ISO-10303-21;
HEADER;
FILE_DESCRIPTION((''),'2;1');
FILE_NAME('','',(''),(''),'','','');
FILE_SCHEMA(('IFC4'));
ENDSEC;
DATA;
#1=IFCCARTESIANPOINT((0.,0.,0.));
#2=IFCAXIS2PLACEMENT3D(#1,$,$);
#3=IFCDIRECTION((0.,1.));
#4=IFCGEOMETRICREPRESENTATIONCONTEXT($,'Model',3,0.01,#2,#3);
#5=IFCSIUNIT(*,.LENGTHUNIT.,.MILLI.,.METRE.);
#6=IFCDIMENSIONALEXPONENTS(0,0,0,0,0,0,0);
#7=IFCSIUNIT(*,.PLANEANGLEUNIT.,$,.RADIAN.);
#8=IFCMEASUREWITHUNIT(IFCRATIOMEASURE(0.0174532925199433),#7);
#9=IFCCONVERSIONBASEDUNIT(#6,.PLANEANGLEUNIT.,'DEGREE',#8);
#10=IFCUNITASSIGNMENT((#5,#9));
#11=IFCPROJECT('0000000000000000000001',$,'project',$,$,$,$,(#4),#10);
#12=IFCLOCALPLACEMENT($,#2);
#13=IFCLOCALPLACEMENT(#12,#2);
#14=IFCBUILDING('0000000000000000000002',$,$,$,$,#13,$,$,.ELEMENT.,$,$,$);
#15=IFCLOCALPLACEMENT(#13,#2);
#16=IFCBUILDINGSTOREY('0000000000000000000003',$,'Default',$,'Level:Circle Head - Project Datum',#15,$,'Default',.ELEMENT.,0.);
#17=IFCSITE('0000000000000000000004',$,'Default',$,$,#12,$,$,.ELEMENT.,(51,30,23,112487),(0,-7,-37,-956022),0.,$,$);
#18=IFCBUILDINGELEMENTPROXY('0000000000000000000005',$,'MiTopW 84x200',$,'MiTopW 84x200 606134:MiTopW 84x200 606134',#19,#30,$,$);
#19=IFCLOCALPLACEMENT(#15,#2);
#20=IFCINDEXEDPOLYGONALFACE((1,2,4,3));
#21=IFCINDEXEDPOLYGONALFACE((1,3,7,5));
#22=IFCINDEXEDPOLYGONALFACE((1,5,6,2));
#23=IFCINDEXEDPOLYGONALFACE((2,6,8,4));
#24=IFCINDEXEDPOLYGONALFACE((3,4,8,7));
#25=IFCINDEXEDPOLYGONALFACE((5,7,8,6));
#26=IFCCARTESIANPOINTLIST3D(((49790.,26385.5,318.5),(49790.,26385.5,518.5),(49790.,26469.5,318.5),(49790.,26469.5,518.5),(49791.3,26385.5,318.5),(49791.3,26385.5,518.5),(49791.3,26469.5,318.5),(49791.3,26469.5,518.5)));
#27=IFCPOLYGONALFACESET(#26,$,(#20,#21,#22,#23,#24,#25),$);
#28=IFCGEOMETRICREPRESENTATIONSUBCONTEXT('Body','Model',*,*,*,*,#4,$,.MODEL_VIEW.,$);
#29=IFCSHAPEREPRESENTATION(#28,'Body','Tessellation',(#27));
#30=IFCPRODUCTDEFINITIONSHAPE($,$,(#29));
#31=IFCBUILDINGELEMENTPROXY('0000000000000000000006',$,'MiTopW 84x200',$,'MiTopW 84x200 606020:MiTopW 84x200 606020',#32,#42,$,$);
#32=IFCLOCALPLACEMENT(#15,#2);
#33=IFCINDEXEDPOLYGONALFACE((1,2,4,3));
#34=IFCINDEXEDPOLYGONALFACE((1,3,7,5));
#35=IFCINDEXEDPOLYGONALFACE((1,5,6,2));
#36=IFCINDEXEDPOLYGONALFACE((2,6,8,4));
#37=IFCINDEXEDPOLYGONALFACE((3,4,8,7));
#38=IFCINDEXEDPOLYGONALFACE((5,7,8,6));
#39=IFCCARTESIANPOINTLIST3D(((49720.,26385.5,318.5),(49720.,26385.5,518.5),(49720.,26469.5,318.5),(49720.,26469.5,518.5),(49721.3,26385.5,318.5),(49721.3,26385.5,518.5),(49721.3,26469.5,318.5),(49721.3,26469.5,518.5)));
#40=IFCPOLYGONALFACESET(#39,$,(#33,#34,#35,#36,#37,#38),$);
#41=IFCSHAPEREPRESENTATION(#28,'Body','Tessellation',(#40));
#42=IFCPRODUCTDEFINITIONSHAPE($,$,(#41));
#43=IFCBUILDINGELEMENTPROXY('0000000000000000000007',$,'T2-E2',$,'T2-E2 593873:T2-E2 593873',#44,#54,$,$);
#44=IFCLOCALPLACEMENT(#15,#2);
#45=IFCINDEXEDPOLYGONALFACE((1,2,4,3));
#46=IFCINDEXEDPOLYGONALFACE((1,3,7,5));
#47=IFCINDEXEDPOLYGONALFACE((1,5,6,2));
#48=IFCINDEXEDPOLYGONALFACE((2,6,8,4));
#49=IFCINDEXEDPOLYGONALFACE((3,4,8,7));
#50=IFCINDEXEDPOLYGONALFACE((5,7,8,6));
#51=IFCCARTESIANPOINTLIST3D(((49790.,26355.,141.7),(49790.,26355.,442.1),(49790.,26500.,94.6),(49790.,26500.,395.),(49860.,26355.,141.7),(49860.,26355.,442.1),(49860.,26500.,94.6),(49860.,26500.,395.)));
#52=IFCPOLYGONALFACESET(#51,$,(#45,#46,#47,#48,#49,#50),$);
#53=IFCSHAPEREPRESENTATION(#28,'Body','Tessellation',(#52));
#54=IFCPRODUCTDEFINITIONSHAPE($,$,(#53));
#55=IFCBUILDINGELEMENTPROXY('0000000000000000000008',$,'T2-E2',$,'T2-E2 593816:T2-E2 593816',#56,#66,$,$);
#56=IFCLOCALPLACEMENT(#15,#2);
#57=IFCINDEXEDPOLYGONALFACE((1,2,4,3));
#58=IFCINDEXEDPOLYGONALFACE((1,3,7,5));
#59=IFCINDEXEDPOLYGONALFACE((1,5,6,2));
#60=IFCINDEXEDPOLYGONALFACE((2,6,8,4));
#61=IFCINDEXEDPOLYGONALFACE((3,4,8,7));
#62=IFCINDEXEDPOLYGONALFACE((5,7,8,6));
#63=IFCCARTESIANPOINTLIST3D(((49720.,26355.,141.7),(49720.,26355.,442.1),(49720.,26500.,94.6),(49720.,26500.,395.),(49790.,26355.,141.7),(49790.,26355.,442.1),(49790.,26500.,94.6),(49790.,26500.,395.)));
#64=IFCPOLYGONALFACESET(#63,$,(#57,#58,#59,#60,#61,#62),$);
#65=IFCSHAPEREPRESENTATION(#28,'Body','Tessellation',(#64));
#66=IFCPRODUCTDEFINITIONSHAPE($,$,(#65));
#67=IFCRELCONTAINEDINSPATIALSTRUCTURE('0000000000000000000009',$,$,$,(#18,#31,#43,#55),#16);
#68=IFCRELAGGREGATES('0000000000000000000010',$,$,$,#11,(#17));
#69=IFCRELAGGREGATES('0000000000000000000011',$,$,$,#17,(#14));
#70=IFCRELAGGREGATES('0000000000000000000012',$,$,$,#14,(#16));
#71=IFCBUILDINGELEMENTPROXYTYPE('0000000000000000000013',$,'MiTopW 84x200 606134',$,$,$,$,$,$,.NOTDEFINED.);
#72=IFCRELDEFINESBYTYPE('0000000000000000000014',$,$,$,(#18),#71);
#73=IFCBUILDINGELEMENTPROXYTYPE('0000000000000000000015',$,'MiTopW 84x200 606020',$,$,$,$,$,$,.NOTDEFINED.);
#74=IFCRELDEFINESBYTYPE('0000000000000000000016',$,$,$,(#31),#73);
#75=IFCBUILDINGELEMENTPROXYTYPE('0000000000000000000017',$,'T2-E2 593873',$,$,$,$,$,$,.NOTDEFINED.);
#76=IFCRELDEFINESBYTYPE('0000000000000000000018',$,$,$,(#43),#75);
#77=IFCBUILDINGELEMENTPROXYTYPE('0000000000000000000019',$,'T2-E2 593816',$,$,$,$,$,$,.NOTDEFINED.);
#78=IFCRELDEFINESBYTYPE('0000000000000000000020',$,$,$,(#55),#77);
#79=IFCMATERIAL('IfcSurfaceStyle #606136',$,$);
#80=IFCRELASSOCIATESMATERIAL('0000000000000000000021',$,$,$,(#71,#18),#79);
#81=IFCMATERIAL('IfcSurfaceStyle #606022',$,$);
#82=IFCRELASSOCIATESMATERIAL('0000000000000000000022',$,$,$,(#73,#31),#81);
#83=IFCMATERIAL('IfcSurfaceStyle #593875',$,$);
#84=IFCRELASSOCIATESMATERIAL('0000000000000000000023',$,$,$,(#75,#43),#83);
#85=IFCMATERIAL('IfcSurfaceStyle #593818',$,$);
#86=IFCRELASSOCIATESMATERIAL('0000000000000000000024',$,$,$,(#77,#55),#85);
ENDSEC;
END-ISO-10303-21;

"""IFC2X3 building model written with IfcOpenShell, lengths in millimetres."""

from ifc_helpers import new_model, entity, si_unit, converted_unit, direction, frame, frame_2d, origin, place, context, subcontext, project, spatial, polyline, rectangle, outline, extrude, source, transform, mapped, material, type_object, type_shapes, element, save


model = new_model("IFC2X3")

# Units and contexts
model_context = context("Model", 3, precision=0.01, world=origin(), true_north=direction((0.0, 1.0)))
body_context = subcontext(model_context, "Body", "Model", "MODEL_VIEW")
ifc_project = project(units=[si_unit("LENGTHUNIT", "METRE", prefix="MILLI"), converted_unit("PLANEANGLEUNIT", "DEGREE", entity("IfcRatioMeasure", 0.0174532925199433), si_unit("PLANEANGLEUNIT", "RADIAN"), dimensions=[0, 0, 0, 0, 0, 0, 0])], contexts=[model_context])

# Site, building, storey
site_placement = place(None, origin())
site = spatial("IfcSite", under=ifc_project, at=site_placement, Name="Default", CompositionType="ELEMENT", RefLatitude=(51, 30, 23, 112487), RefLongitude=(0, -7, -37, -956022), RefElevation=0.0)
building_placement = place(site_placement, origin())
building = spatial("IfcBuilding", under=site, at=building_placement, CompositionType="ELEMENT")
storey_placement = place(building_placement, origin())
storey = spatial("IfcBuildingStorey", under=building, at=storey_placement, Name="Default", ObjectType="Level:Circle Head - Project Datum", LongName="Default", CompositionType="ELEMENT", Elevation=0.0)

# Building element proxies
ifc_material_1 = material(Name="IfcSurfaceStyle #606136")
building_element_proxy_type_1 = type_object("IfcBuildingElementProxyType", Name="MiTopW 84x200 606134", PredefinedType="NOTDEFINED", material=ifc_material_1)
shared_shape_1 = source(origin(), body_context, "Body", "SweptSolid", [
    extrude(rectangle(XDim=200.0, YDim=84.0, at=frame_2d((0.0, 0.0), x_axis=(1.0, 0.0))), frame((100.0, 42.0, 0.0), z_axis=(0.0, 0.0, 1.0), x_axis=(-1.0, 0.0, 0.0)), (0.0, 0.0, 1.0), 1.3),
])
type_shapes(building_element_proxy_type_1, [shared_shape_1])
proxy_1_placement = place(building_placement, frame((49791.3, 26469.5, 518.5), z_axis=(-1.0, 0.0, 0.0), x_axis=(0.0, 0.0, -1.0)))
element("IfcBuildingElementProxy", 1, at=proxy_1_placement, inside=storey, type_object=building_element_proxy_type_1, material=ifc_material_1, Name="MiTopW 84x200", ObjectType="MiTopW 84x200 606134:MiTopW 84x200 606134", context=body_context, shape_type="MappedRepresentation", body=[
    mapped(shared_shape_1, transform((0.0, 0.0, 0.0), scale=1.0)),
])
ifc_material_2 = material(Name="IfcSurfaceStyle #606022")
building_element_proxy_type_2 = type_object("IfcBuildingElementProxyType", Name="MiTopW 84x200 606020", PredefinedType="NOTDEFINED", material=ifc_material_2)
shared_shape_2 = source(origin(), body_context, "Body", "SweptSolid", [
    extrude(rectangle(XDim=200.0, YDim=84.0, at=frame_2d((0.0, 0.0), x_axis=(1.0, 0.0))), frame((100.0, 42.0, 0.0), z_axis=(0.0, 0.0, 1.0), x_axis=(-1.0, 0.0, 0.0)), (0.0, 0.0, 1.0), 1.3),
])
type_shapes(building_element_proxy_type_2, [shared_shape_2])
proxy_2_placement = place(building_placement, frame((49721.3, 26469.5, 518.5), z_axis=(-1.0, 0.0, 0.0), x_axis=(0.0, 0.0, -1.0)))
element("IfcBuildingElementProxy", 2, at=proxy_2_placement, inside=storey, type_object=building_element_proxy_type_2, material=ifc_material_2, Name="MiTopW 84x200", ObjectType="MiTopW 84x200 606020:MiTopW 84x200 606020", context=body_context, shape_type="MappedRepresentation", body=[
    mapped(shared_shape_2, transform((0.0, 0.0, 0.0), scale=1.0)),
])
ifc_material_3 = material(Name="IfcSurfaceStyle #593875")
building_element_proxy_type_3 = type_object("IfcBuildingElementProxyType", Name="T2-E2 593873", PredefinedType="NOTDEFINED", material=ifc_material_3)
shared_shape_3 = source(origin(), body_context, "Body", "SweptSolid", [
    extrude(outline(polyline([(-126.6, -72.5), (173.8, -72.5), (126.6, 72.5), (-173.8, 72.5), (-126.6, -72.5)])), frame((173.8, 72.5, 0.0), z_axis=(0.0, 0.0, 1.0), x_axis=(-1.0, 0.0, 0.0)), (0.0, 0.0, 1.0), 70.0),
])
type_shapes(building_element_proxy_type_3, [shared_shape_3])
proxy_3_placement = place(building_placement, frame((49860.0, 26500.0, 442.1), z_axis=(-1.0, 0.0, 0.0), x_axis=(0.0, 0.0, -1.0)))
element("IfcBuildingElementProxy", 3, at=proxy_3_placement, inside=storey, type_object=building_element_proxy_type_3, material=ifc_material_3, Name="T2-E2", ObjectType="T2-E2 593873:T2-E2 593873", context=body_context, shape_type="MappedRepresentation", body=[
    mapped(shared_shape_3, transform((0.0, 0.0, 0.0), scale=1.0)),
])
ifc_material_4 = material(Name="IfcSurfaceStyle #593818")
building_element_proxy_type_4 = type_object("IfcBuildingElementProxyType", Name="T2-E2 593816", PredefinedType="NOTDEFINED", material=ifc_material_4)
shared_shape_4 = source(origin(), body_context, "Body", "SweptSolid", [
    extrude(outline(polyline([(-126.6, -72.5), (173.8, -72.5), (126.6, 72.5), (-173.8, 72.5), (-126.6, -72.5)])), frame((173.8, 72.5, 0.0), z_axis=(0.0, 0.0, 1.0), x_axis=(-1.0, 0.0, 0.0)), (0.0, 0.0, 1.0), 70.0),
])
type_shapes(building_element_proxy_type_4, [shared_shape_4])
proxy_4_placement = place(building_placement, frame((49790.0, 26500.0, 442.1), z_axis=(-1.0, 0.0, 0.0), x_axis=(0.0, 0.0, -1.0)))
element("IfcBuildingElementProxy", 4, at=proxy_4_placement, inside=storey, type_object=building_element_proxy_type_4, material=ifc_material_4, Name="T2-E2", ObjectType="T2-E2 593816:T2-E2 593816", context=body_context, shape_type="MappedRepresentation", body=[
    mapped(shared_shape_4, transform((0.0, 0.0, 0.0), scale=1.0)),
])

save(model, "model.ifc")
